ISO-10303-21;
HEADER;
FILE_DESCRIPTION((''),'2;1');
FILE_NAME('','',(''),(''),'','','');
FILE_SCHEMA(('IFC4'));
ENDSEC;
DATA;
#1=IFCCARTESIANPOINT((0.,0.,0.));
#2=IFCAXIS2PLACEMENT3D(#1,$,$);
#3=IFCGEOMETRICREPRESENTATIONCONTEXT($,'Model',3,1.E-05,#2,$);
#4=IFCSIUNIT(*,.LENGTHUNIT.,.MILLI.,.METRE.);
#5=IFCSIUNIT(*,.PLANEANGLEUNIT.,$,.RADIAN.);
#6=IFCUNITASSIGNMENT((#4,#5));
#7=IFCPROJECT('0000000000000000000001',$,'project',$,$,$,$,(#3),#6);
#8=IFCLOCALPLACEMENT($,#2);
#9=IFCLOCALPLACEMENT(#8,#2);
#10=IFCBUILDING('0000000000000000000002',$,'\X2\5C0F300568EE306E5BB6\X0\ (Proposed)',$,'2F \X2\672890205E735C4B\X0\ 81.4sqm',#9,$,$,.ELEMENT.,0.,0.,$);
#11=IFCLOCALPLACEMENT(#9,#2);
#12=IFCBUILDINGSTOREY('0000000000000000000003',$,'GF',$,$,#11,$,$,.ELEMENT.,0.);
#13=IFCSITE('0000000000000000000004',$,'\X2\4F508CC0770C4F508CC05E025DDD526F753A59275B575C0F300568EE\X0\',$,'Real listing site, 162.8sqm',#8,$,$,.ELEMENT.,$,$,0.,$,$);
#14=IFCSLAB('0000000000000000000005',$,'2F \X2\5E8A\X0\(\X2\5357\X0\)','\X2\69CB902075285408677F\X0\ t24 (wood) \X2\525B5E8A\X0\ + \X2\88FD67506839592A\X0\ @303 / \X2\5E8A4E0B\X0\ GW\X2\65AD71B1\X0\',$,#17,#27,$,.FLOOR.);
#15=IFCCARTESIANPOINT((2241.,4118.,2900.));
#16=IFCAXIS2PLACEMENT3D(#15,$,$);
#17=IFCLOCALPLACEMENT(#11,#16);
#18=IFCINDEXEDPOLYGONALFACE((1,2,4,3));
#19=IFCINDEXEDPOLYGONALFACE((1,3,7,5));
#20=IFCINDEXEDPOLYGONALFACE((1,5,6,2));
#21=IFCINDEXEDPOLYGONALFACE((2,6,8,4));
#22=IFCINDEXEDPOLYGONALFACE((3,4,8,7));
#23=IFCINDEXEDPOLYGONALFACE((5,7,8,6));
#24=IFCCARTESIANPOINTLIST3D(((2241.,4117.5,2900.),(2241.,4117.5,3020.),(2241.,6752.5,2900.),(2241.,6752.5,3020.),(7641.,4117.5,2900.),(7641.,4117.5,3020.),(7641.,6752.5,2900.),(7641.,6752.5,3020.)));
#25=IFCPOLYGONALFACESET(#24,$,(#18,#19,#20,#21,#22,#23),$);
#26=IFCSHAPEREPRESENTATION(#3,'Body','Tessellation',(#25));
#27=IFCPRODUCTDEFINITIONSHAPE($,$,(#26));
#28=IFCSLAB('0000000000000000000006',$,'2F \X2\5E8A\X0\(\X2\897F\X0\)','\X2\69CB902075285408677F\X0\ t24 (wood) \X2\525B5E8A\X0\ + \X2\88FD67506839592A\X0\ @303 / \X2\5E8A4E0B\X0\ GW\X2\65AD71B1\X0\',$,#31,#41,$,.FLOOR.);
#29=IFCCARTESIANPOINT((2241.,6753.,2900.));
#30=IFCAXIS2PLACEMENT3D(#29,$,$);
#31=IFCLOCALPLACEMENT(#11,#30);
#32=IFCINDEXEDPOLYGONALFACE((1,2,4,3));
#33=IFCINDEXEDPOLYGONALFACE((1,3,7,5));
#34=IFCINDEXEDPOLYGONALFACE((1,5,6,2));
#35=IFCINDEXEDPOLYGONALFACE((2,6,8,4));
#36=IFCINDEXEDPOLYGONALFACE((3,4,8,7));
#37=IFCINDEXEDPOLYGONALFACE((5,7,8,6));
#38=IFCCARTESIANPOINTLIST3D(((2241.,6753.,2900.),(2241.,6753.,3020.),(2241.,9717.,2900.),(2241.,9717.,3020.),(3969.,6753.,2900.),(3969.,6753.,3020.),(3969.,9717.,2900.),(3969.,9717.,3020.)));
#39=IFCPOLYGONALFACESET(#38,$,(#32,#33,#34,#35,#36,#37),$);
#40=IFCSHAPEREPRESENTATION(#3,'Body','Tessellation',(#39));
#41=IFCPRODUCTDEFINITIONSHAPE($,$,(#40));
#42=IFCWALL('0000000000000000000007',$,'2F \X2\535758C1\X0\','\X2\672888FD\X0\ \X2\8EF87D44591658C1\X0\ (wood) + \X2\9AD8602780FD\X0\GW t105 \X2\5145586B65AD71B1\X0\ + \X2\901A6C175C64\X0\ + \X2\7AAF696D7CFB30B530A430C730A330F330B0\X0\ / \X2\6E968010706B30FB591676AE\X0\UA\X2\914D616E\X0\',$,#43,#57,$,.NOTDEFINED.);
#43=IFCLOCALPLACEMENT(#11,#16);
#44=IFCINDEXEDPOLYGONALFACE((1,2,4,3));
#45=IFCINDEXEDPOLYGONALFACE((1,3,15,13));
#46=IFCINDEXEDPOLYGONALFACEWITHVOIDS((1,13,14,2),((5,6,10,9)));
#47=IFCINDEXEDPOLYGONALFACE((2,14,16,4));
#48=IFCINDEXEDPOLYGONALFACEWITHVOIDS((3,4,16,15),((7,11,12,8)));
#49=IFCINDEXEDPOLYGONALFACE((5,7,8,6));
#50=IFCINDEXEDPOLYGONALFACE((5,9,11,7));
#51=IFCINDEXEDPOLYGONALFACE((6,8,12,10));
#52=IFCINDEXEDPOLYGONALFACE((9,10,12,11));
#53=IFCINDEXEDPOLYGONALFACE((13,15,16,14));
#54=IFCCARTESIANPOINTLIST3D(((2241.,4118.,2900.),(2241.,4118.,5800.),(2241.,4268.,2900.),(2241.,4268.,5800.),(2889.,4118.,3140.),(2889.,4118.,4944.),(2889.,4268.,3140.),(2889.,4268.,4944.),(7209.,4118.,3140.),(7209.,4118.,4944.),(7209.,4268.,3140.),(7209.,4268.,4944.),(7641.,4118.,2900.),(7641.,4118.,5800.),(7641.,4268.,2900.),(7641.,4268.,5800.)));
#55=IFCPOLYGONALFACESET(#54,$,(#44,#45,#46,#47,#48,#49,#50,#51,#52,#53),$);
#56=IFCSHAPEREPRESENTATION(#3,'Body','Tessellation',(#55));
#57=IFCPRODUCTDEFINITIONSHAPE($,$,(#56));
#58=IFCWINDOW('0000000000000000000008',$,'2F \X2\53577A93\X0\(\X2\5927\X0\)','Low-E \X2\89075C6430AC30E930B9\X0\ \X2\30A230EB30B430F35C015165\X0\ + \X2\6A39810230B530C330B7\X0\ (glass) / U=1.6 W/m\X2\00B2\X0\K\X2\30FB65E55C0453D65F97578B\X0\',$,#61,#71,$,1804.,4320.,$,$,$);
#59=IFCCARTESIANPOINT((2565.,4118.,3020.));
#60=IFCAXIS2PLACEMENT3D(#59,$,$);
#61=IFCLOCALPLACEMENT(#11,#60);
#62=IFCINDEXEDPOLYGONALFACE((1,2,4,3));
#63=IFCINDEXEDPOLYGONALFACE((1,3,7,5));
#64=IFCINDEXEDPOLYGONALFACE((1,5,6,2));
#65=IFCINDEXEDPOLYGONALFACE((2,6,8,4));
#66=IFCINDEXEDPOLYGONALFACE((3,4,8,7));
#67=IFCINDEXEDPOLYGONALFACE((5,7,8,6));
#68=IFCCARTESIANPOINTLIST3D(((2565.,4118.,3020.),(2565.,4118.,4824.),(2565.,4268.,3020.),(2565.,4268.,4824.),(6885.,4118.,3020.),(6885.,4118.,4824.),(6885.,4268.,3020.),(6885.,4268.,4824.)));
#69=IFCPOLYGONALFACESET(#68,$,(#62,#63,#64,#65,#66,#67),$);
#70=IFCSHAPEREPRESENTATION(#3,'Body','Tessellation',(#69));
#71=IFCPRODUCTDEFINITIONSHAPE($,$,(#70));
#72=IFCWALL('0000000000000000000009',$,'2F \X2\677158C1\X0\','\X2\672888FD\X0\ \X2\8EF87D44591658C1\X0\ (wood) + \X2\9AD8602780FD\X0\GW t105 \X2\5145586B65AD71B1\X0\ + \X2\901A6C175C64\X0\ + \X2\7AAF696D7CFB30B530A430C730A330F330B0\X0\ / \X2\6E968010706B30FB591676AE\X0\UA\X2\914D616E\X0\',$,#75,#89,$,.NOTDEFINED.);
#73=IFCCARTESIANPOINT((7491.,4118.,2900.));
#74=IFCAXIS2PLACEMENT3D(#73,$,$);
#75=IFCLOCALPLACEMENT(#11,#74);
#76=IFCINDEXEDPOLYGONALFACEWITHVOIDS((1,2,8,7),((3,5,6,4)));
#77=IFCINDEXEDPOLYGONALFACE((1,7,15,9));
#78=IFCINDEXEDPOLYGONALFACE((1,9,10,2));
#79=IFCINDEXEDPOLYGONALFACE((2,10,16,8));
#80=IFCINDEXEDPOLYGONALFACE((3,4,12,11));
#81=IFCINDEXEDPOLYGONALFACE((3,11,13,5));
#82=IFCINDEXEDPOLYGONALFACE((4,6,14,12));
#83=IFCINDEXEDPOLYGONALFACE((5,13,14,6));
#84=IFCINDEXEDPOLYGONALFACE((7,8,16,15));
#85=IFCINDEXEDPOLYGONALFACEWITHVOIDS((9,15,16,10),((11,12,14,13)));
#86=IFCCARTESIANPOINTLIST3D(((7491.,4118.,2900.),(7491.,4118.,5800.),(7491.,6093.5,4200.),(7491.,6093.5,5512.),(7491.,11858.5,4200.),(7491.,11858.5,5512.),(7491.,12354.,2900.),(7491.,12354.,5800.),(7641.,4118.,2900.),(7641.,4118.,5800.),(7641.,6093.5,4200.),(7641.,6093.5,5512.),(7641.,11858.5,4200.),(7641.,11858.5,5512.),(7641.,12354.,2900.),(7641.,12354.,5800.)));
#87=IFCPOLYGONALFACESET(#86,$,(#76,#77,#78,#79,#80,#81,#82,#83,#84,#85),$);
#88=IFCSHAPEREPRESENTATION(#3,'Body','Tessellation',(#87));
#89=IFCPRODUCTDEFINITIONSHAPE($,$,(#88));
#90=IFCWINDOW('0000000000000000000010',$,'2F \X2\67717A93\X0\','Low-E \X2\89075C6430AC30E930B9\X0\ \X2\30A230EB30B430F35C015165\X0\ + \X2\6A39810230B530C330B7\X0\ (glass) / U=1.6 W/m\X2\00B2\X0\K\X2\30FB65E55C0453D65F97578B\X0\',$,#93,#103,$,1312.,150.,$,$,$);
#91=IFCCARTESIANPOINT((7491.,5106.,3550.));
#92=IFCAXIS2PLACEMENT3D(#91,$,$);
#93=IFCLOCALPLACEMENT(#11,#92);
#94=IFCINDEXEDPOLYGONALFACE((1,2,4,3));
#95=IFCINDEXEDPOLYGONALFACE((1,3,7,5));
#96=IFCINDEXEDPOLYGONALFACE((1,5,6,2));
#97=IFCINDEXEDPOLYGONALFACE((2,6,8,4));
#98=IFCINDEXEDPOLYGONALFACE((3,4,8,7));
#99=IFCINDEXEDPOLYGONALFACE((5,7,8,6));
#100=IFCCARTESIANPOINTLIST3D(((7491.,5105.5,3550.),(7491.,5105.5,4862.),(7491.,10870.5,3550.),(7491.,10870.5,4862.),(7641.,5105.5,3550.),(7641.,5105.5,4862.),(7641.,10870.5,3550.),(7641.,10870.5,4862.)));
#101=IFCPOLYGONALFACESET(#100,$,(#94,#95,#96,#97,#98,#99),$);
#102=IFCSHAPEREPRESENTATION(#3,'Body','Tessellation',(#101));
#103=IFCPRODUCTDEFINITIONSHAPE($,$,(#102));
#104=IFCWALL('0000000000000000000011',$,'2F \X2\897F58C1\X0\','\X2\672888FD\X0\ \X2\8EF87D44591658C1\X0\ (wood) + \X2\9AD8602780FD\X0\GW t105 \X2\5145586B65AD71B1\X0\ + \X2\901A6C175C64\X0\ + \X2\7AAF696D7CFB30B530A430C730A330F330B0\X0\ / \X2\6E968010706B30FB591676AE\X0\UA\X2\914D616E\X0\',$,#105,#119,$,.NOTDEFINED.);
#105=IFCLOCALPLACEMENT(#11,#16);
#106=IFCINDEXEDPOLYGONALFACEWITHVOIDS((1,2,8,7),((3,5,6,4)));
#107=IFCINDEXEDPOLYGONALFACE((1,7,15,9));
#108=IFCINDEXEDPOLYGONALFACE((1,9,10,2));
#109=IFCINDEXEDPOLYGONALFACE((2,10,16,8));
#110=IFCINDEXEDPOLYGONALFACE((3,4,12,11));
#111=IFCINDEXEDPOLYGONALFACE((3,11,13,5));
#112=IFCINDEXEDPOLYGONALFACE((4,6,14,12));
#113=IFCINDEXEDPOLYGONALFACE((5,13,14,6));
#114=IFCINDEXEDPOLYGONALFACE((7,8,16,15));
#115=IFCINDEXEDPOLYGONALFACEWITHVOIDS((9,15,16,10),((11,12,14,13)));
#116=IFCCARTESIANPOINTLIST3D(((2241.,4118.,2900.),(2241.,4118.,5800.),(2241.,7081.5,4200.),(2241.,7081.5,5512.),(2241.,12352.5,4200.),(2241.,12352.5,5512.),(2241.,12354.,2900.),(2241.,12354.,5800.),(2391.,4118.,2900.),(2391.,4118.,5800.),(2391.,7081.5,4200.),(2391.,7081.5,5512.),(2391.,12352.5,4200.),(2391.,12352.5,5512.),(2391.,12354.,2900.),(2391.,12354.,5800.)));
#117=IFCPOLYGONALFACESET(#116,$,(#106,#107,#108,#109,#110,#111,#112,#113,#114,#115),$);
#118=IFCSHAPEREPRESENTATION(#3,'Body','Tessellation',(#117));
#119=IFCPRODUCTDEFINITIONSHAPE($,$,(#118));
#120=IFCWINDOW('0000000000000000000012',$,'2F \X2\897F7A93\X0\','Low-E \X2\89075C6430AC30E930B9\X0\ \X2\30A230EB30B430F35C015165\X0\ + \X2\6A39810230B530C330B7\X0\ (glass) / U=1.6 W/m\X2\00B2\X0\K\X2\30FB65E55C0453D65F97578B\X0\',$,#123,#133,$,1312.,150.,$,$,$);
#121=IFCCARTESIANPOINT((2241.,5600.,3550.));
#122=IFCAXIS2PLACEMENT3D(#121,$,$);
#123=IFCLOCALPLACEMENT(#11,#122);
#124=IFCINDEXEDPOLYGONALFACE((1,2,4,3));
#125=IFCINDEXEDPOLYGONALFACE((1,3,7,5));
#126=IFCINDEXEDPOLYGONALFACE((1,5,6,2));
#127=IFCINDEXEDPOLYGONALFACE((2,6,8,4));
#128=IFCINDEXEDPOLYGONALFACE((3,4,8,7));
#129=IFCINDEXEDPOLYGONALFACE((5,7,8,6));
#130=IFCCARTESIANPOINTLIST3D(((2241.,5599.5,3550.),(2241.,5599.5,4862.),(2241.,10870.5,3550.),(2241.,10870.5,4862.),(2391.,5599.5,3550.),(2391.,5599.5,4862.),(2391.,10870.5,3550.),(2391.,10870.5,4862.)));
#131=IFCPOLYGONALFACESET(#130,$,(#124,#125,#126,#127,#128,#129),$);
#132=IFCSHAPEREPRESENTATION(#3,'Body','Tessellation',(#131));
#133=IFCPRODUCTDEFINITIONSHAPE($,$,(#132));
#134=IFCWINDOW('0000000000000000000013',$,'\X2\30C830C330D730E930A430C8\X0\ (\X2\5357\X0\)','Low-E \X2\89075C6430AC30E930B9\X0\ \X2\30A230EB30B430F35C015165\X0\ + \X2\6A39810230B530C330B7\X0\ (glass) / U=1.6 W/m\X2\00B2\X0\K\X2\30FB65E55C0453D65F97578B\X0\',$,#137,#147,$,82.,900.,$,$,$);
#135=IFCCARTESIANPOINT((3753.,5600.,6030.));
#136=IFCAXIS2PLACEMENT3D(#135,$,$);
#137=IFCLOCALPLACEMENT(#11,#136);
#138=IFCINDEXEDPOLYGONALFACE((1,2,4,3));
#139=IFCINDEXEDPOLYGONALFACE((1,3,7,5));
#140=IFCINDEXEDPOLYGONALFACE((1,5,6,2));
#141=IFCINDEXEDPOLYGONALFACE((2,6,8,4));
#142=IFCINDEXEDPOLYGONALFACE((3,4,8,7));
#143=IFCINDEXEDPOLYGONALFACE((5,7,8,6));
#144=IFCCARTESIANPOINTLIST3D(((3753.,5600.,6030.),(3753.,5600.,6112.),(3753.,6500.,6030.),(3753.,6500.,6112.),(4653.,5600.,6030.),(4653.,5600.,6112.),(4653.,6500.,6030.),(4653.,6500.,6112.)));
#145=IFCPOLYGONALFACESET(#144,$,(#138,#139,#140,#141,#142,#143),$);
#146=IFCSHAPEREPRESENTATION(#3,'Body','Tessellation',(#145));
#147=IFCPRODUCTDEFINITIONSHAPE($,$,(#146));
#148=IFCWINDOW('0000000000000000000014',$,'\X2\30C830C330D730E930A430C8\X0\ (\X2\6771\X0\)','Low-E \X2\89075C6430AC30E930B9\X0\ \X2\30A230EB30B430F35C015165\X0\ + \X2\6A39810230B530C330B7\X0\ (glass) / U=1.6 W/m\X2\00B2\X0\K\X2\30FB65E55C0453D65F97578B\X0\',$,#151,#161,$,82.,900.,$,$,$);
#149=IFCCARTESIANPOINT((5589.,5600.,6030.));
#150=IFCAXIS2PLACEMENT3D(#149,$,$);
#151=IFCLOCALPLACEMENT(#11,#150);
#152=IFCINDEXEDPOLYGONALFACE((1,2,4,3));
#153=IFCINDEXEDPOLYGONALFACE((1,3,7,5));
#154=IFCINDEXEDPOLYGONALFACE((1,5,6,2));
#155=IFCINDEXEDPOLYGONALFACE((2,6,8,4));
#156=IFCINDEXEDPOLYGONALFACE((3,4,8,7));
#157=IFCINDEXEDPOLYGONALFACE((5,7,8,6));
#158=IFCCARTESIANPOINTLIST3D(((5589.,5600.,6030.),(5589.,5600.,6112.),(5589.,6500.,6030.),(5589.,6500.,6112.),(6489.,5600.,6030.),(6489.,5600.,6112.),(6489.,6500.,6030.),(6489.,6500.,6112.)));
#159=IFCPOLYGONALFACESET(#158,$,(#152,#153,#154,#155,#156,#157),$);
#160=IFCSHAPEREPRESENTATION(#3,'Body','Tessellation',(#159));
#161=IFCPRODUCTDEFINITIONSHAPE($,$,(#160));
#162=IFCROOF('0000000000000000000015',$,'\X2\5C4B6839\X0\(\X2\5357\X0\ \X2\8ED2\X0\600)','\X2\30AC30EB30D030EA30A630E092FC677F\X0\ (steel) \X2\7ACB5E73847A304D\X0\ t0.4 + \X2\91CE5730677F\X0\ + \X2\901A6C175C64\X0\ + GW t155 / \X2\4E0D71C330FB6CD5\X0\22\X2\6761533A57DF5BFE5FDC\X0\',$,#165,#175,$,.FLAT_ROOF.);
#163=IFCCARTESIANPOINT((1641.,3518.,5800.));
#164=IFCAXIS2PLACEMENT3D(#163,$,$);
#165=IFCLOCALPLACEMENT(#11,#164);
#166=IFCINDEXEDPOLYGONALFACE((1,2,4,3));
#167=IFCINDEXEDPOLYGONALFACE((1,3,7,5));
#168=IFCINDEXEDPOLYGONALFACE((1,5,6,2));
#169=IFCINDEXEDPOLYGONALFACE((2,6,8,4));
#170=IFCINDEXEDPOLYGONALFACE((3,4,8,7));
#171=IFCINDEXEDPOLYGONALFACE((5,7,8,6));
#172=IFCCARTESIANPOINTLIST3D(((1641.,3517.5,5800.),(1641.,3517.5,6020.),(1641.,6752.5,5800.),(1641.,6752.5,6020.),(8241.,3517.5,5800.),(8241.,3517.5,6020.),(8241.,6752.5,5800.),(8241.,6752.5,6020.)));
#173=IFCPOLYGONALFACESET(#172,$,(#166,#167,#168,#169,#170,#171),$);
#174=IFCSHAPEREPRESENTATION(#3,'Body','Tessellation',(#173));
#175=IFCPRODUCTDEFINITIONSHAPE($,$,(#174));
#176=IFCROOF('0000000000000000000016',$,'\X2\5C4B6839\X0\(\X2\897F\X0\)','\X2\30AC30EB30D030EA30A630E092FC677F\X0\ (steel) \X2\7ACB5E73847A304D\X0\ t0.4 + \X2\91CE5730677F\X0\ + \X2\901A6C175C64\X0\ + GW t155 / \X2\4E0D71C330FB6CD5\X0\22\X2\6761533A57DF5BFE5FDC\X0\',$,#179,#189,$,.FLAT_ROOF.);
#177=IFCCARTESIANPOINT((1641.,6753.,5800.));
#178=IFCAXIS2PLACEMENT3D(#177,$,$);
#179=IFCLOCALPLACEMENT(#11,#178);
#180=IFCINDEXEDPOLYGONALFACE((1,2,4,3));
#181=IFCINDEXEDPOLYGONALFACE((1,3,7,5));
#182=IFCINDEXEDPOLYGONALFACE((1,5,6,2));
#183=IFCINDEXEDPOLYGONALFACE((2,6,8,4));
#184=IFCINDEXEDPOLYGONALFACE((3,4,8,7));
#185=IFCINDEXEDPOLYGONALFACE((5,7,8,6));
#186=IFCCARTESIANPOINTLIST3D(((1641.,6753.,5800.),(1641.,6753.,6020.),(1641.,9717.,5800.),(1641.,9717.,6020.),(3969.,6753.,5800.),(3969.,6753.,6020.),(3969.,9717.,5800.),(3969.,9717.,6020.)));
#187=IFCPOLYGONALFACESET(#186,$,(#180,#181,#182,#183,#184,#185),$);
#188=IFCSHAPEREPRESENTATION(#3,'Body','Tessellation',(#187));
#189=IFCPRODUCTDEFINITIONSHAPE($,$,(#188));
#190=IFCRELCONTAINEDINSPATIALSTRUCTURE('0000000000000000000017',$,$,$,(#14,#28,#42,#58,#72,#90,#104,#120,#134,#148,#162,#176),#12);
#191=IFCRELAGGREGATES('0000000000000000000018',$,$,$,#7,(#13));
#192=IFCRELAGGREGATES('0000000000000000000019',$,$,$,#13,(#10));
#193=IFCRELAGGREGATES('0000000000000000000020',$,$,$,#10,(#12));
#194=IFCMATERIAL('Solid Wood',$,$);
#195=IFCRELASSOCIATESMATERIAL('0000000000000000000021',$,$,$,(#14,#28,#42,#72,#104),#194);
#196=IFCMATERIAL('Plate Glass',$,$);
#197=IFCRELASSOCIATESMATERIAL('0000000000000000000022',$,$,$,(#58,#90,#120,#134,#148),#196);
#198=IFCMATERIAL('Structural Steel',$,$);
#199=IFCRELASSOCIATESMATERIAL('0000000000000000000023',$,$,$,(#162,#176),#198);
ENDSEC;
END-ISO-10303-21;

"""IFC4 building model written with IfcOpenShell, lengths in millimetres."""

from ifc_helpers import new_model, si_unit, frame, frame_2d, origin, place, context, project, spatial, rectangle, extrude, material, element, fill, save


model = new_model("IFC4")

# Units and contexts
model_context = context("Model", 3, precision=1e-05, world=origin())
ifc_project = project(units=[si_unit("LENGTHUNIT", "METRE", prefix="MILLI"), si_unit("PLANEANGLEUNIT", "RADIAN")], contexts=[model_context])

# Site, building, storey
site_placement = place(None, origin())
site = spatial("IfcSite", under=ifc_project, at=site_placement, Name="佐賀県佐賀市川副町大字小々森", ObjectType="Real listing site, 162.8sqm", CompositionType="ELEMENT", RefElevation=0.0)
building_placement = place(site_placement, origin())
building = spatial("IfcBuilding", under=site, at=building_placement, Name="小々森の家 (Proposed)", ObjectType="2F 木造平屋 81.4sqm", CompositionType="ELEMENT", ElevationOfRefHeight=0.0, ElevationOfTerrain=0.0)
storey_placement = place(building_placement, origin())
storey = spatial("IfcBuildingStorey", under=building, at=storey_placement, Name="GF", CompositionType="ELEMENT", Elevation=0.0)

# Slabs
ifc_material_1 = material(Name="Solid Wood")
slab_1_placement = place(storey_placement, frame((2241.0, 4118.0, 2900.0)))
element("IfcSlab", 1, at=slab_1_placement, inside=storey, material=ifc_material_1, Name="2F 床(南)", Description="構造用合板 t24 (wood) 剛床 + 製材根太 @303 / 床下 GW断熱", PredefinedType="FLOOR", context=model_context, shape_type="SweptSolid", body=[
    extrude(rectangle(XDim=5400.0, YDim=2635.0, at=frame_2d((2700.0, 1317.0))), frame((2241.0, 4118.0, 2900.0)), (0.0, 0.0, 1.0), 120.0),
])
slab_2_placement = place(storey_placement, frame((2241.0, 6753.0, 2900.0)))
element("IfcSlab", 2, at=slab_2_placement, inside=storey, material=ifc_material_1, Name="2F 床(西)", Description="構造用合板 t24 (wood) 剛床 + 製材根太 @303 / 床下 GW断熱", PredefinedType="FLOOR", context=model_context, shape_type="SweptSolid", body=[
    extrude(rectangle(XDim=1728.0, YDim=2964.0, at=frame_2d((864.0, 1482.0))), frame((2241.0, 6753.0, 2900.0)), (0.0, 0.0, 1.0), 120.0),
])

# Walls, openings, windows
wall_1_placement = place(storey_placement, frame((2241.0, 4118.0, 2900.0)))
wall_1 = element("IfcWall", 3, at=wall_1_placement, inside=storey, material=ifc_material_1, Name="2F 南壁", Description="木製 軸組外壁 (wood) + 高性能GW t105 充填断熱 + 通気層 + 窯業系サイディング / 準耐火・外皮UA配慮", PredefinedType="NOTDEFINED", context=model_context, shape_type="SweptSolid", body=[
    extrude(rectangle(XDim=5400.0, YDim=150.0, at=frame_2d((2700.0, 75.0))), frame((2241.0, 4118.0, 2900.0)), (0.0, 0.0, 1.0), 2900.0),
])
opening_1_placement = place(storey_placement, frame((2565.0, 4118.0, 3020.0)))
opening_1 = element("IfcOpeningElement", 4, at=opening_1_placement, cuts=wall_1, PredefinedType="NOTDEFINED", context=model_context, shape_type="SweptSolid", body=[
    extrude(rectangle(XDim=4320.0, YDim=150.0, at=frame_2d((2160.0, 75.0))), frame((2565.0, 4118.0, 3020.0)), (0.0, 0.0, 1.0), 1804.0),
])
ifc_material_2 = material(Name="Plate Glass")
window_1_placement = place(storey_placement, frame((2565.0, 4118.0, 3020.0)))
window_1 = element("IfcWindow", 5, at=window_1_placement, inside=storey, material=ifc_material_2, Name="2F 南窓(大)", Description="Low-E 複層ガラス アルゴン封入 + 樹脂サッシ (glass) / U=1.6 W/m²K・日射取得型", OverallHeight=1804.0, OverallWidth=4320.0, context=model_context, shape_type="SweptSolid", body=[
    extrude(rectangle(XDim=4320.0, YDim=150.0, at=frame_2d((2160.0, 75.0))), frame((2565.0, 4118.0, 3020.0)), (0.0, 0.0, 1.0), 1804.0),
])
fill(opening_1, window_1)
wall_2_placement = place(storey_placement, frame((7491.0, 4118.0, 2900.0)))
wall_2 = element("IfcWall", 6, at=wall_2_placement, inside=storey, material=ifc_material_1, Name="2F 東壁", Description="木製 軸組外壁 (wood) + 高性能GW t105 充填断熱 + 通気層 + 窯業系サイディング / 準耐火・外皮UA配慮", PredefinedType="NOTDEFINED", context=model_context, shape_type="SweptSolid", body=[
    extrude(rectangle(XDim=150.0, YDim=8236.0, at=frame_2d((75.0, 4118.0))), frame((7491.0, 4118.0, 2900.0)), (0.0, 0.0, 1.0), 2900.0),
])
opening_2_placement = place(storey_placement, frame((7491.0, 5106.0, 3550.0)))
opening_2 = element("IfcOpeningElement", 7, at=opening_2_placement, cuts=wall_2, PredefinedType="NOTDEFINED", context=model_context, shape_type="SweptSolid", body=[
    extrude(rectangle(XDim=150.0, YDim=5765.0, at=frame_2d((75.0, 2882.0))), frame((7491.0, 5106.0, 3550.0)), (0.0, 0.0, 1.0), 1312.0),
])
window_2_placement = place(storey_placement, frame((7491.0, 5106.0, 3550.0)))
window_2 = element("IfcWindow", 8, at=window_2_placement, inside=storey, material=ifc_material_2, Name="2F 東窓", Description="Low-E 複層ガラス アルゴン封入 + 樹脂サッシ (glass) / U=1.6 W/m²K・日射取得型", OverallHeight=1312.0, OverallWidth=150.0, context=model_context, shape_type="SweptSolid", body=[
    extrude(rectangle(XDim=150.0, YDim=5765.0, at=frame_2d((75.0, 2882.0))), frame((7491.0, 5106.0, 3550.0)), (0.0, 0.0, 1.0), 1312.0),
])
fill(opening_2, window_2)
wall_3_placement = place(storey_placement, frame((2241.0, 4118.0, 2900.0)))
wall_3 = element("IfcWall", 9, at=wall_3_placement, inside=storey, material=ifc_material_1, Name="2F 西壁", Description="木製 軸組外壁 (wood) + 高性能GW t105 充填断熱 + 通気層 + 窯業系サイディング / 準耐火・外皮UA配慮", PredefinedType="NOTDEFINED", context=model_context, shape_type="SweptSolid", body=[
    extrude(rectangle(XDim=150.0, YDim=8236.0, at=frame_2d((75.0, 4118.0))), frame((2241.0, 4118.0, 2900.0)), (0.0, 0.0, 1.0), 2900.0),
])
opening_3_placement = place(storey_placement, frame((2241.0, 5600.0, 3550.0)))
opening_3 = element("IfcOpeningElement", 10, at=opening_3_placement, cuts=wall_3, PredefinedType="NOTDEFINED", context=model_context, shape_type="SweptSolid", body=[
    extrude(rectangle(XDim=150.0, YDim=5271.0, at=frame_2d((75.0, 2635.0))), frame((2241.0, 5600.0, 3550.0)), (0.0, 0.0, 1.0), 1312.0),
])
window_3_placement = place(storey_placement, frame((2241.0, 5600.0, 3550.0)))
window_3 = element("IfcWindow", 11, at=window_3_placement, inside=storey, material=ifc_material_2, Name="2F 西窓", Description="Low-E 複層ガラス アルゴン封入 + 樹脂サッシ (glass) / U=1.6 W/m²K・日射取得型", OverallHeight=1312.0, OverallWidth=150.0, context=model_context, shape_type="SweptSolid", body=[
    extrude(rectangle(XDim=150.0, YDim=5271.0, at=frame_2d((75.0, 2635.0))), frame((2241.0, 5600.0, 3550.0)), (0.0, 0.0, 1.0), 1312.0),
])
fill(opening_3, window_3)

# Windows
window_4_placement = place(storey_placement, frame((3753.0, 5600.0, 6030.0)))
element("IfcWindow", 12, at=window_4_placement, inside=storey, material=ifc_material_2, Name="トップライト (南)", Description="Low-E 複層ガラス アルゴン封入 + 樹脂サッシ (glass) / U=1.6 W/m²K・日射取得型", OverallHeight=82.0, OverallWidth=900.0, context=model_context, shape_type="SweptSolid", body=[
    extrude(rectangle(XDim=900.0, YDim=900.0, at=frame_2d((450.0, 450.0))), frame((3753.0, 5600.0, 6030.0)), (0.0, 0.0, 1.0), 82.0),
])
window_5_placement = place(storey_placement, frame((5589.0, 5600.0, 6030.0)))
element("IfcWindow", 13, at=window_5_placement, inside=storey, material=ifc_material_2, Name="トップライト (東)", Description="Low-E 複層ガラス アルゴン封入 + 樹脂サッシ (glass) / U=1.6 W/m²K・日射取得型", OverallHeight=82.0, OverallWidth=900.0, context=model_context, shape_type="SweptSolid", body=[
    extrude(rectangle(XDim=900.0, YDim=900.0, at=frame_2d((450.0, 450.0))), frame((5589.0, 5600.0, 6030.0)), (0.0, 0.0, 1.0), 82.0),
])

# Roofs
ifc_material_3 = material(Name="Structural Steel")
roof_1_placement = place(storey_placement, frame((1641.0, 3518.0, 5800.0)))
element("IfcRoof", 14, at=roof_1_placement, inside=storey, material=ifc_material_3, Name="屋根(南 軒600)", Description="ガルバリウム鋼板 (steel) 立平葺き t0.4 + 野地板 + 通気層 + GW t155 / 不燃・法22条区域対応", PredefinedType="FLAT_ROOF", context=model_context, shape_type="SweptSolid", body=[
    extrude(rectangle(XDim=6600.0, YDim=3235.0, at=frame_2d((3300.0, 1617.0))), frame((1641.0, 3518.0, 5800.0)), (0.0, 0.0, 1.0), 220.0),
])
roof_2_placement = place(storey_placement, frame((1641.0, 6753.0, 5800.0)))
element("IfcRoof", 15, at=roof_2_placement, inside=storey, material=ifc_material_3, Name="屋根(西)", Description="ガルバリウム鋼板 (steel) 立平葺き t0.4 + 野地板 + 通気層 + GW t155 / 不燃・法22条区域対応", PredefinedType="FLAT_ROOF", context=model_context, shape_type="SweptSolid", body=[
    extrude(rectangle(XDim=2328.0, YDim=2964.0, at=frame_2d((1164.0, 1482.0))), frame((1641.0, 6753.0, 5800.0)), (0.0, 0.0, 1.0), 220.0),
])

save(model, "model.ifc")
